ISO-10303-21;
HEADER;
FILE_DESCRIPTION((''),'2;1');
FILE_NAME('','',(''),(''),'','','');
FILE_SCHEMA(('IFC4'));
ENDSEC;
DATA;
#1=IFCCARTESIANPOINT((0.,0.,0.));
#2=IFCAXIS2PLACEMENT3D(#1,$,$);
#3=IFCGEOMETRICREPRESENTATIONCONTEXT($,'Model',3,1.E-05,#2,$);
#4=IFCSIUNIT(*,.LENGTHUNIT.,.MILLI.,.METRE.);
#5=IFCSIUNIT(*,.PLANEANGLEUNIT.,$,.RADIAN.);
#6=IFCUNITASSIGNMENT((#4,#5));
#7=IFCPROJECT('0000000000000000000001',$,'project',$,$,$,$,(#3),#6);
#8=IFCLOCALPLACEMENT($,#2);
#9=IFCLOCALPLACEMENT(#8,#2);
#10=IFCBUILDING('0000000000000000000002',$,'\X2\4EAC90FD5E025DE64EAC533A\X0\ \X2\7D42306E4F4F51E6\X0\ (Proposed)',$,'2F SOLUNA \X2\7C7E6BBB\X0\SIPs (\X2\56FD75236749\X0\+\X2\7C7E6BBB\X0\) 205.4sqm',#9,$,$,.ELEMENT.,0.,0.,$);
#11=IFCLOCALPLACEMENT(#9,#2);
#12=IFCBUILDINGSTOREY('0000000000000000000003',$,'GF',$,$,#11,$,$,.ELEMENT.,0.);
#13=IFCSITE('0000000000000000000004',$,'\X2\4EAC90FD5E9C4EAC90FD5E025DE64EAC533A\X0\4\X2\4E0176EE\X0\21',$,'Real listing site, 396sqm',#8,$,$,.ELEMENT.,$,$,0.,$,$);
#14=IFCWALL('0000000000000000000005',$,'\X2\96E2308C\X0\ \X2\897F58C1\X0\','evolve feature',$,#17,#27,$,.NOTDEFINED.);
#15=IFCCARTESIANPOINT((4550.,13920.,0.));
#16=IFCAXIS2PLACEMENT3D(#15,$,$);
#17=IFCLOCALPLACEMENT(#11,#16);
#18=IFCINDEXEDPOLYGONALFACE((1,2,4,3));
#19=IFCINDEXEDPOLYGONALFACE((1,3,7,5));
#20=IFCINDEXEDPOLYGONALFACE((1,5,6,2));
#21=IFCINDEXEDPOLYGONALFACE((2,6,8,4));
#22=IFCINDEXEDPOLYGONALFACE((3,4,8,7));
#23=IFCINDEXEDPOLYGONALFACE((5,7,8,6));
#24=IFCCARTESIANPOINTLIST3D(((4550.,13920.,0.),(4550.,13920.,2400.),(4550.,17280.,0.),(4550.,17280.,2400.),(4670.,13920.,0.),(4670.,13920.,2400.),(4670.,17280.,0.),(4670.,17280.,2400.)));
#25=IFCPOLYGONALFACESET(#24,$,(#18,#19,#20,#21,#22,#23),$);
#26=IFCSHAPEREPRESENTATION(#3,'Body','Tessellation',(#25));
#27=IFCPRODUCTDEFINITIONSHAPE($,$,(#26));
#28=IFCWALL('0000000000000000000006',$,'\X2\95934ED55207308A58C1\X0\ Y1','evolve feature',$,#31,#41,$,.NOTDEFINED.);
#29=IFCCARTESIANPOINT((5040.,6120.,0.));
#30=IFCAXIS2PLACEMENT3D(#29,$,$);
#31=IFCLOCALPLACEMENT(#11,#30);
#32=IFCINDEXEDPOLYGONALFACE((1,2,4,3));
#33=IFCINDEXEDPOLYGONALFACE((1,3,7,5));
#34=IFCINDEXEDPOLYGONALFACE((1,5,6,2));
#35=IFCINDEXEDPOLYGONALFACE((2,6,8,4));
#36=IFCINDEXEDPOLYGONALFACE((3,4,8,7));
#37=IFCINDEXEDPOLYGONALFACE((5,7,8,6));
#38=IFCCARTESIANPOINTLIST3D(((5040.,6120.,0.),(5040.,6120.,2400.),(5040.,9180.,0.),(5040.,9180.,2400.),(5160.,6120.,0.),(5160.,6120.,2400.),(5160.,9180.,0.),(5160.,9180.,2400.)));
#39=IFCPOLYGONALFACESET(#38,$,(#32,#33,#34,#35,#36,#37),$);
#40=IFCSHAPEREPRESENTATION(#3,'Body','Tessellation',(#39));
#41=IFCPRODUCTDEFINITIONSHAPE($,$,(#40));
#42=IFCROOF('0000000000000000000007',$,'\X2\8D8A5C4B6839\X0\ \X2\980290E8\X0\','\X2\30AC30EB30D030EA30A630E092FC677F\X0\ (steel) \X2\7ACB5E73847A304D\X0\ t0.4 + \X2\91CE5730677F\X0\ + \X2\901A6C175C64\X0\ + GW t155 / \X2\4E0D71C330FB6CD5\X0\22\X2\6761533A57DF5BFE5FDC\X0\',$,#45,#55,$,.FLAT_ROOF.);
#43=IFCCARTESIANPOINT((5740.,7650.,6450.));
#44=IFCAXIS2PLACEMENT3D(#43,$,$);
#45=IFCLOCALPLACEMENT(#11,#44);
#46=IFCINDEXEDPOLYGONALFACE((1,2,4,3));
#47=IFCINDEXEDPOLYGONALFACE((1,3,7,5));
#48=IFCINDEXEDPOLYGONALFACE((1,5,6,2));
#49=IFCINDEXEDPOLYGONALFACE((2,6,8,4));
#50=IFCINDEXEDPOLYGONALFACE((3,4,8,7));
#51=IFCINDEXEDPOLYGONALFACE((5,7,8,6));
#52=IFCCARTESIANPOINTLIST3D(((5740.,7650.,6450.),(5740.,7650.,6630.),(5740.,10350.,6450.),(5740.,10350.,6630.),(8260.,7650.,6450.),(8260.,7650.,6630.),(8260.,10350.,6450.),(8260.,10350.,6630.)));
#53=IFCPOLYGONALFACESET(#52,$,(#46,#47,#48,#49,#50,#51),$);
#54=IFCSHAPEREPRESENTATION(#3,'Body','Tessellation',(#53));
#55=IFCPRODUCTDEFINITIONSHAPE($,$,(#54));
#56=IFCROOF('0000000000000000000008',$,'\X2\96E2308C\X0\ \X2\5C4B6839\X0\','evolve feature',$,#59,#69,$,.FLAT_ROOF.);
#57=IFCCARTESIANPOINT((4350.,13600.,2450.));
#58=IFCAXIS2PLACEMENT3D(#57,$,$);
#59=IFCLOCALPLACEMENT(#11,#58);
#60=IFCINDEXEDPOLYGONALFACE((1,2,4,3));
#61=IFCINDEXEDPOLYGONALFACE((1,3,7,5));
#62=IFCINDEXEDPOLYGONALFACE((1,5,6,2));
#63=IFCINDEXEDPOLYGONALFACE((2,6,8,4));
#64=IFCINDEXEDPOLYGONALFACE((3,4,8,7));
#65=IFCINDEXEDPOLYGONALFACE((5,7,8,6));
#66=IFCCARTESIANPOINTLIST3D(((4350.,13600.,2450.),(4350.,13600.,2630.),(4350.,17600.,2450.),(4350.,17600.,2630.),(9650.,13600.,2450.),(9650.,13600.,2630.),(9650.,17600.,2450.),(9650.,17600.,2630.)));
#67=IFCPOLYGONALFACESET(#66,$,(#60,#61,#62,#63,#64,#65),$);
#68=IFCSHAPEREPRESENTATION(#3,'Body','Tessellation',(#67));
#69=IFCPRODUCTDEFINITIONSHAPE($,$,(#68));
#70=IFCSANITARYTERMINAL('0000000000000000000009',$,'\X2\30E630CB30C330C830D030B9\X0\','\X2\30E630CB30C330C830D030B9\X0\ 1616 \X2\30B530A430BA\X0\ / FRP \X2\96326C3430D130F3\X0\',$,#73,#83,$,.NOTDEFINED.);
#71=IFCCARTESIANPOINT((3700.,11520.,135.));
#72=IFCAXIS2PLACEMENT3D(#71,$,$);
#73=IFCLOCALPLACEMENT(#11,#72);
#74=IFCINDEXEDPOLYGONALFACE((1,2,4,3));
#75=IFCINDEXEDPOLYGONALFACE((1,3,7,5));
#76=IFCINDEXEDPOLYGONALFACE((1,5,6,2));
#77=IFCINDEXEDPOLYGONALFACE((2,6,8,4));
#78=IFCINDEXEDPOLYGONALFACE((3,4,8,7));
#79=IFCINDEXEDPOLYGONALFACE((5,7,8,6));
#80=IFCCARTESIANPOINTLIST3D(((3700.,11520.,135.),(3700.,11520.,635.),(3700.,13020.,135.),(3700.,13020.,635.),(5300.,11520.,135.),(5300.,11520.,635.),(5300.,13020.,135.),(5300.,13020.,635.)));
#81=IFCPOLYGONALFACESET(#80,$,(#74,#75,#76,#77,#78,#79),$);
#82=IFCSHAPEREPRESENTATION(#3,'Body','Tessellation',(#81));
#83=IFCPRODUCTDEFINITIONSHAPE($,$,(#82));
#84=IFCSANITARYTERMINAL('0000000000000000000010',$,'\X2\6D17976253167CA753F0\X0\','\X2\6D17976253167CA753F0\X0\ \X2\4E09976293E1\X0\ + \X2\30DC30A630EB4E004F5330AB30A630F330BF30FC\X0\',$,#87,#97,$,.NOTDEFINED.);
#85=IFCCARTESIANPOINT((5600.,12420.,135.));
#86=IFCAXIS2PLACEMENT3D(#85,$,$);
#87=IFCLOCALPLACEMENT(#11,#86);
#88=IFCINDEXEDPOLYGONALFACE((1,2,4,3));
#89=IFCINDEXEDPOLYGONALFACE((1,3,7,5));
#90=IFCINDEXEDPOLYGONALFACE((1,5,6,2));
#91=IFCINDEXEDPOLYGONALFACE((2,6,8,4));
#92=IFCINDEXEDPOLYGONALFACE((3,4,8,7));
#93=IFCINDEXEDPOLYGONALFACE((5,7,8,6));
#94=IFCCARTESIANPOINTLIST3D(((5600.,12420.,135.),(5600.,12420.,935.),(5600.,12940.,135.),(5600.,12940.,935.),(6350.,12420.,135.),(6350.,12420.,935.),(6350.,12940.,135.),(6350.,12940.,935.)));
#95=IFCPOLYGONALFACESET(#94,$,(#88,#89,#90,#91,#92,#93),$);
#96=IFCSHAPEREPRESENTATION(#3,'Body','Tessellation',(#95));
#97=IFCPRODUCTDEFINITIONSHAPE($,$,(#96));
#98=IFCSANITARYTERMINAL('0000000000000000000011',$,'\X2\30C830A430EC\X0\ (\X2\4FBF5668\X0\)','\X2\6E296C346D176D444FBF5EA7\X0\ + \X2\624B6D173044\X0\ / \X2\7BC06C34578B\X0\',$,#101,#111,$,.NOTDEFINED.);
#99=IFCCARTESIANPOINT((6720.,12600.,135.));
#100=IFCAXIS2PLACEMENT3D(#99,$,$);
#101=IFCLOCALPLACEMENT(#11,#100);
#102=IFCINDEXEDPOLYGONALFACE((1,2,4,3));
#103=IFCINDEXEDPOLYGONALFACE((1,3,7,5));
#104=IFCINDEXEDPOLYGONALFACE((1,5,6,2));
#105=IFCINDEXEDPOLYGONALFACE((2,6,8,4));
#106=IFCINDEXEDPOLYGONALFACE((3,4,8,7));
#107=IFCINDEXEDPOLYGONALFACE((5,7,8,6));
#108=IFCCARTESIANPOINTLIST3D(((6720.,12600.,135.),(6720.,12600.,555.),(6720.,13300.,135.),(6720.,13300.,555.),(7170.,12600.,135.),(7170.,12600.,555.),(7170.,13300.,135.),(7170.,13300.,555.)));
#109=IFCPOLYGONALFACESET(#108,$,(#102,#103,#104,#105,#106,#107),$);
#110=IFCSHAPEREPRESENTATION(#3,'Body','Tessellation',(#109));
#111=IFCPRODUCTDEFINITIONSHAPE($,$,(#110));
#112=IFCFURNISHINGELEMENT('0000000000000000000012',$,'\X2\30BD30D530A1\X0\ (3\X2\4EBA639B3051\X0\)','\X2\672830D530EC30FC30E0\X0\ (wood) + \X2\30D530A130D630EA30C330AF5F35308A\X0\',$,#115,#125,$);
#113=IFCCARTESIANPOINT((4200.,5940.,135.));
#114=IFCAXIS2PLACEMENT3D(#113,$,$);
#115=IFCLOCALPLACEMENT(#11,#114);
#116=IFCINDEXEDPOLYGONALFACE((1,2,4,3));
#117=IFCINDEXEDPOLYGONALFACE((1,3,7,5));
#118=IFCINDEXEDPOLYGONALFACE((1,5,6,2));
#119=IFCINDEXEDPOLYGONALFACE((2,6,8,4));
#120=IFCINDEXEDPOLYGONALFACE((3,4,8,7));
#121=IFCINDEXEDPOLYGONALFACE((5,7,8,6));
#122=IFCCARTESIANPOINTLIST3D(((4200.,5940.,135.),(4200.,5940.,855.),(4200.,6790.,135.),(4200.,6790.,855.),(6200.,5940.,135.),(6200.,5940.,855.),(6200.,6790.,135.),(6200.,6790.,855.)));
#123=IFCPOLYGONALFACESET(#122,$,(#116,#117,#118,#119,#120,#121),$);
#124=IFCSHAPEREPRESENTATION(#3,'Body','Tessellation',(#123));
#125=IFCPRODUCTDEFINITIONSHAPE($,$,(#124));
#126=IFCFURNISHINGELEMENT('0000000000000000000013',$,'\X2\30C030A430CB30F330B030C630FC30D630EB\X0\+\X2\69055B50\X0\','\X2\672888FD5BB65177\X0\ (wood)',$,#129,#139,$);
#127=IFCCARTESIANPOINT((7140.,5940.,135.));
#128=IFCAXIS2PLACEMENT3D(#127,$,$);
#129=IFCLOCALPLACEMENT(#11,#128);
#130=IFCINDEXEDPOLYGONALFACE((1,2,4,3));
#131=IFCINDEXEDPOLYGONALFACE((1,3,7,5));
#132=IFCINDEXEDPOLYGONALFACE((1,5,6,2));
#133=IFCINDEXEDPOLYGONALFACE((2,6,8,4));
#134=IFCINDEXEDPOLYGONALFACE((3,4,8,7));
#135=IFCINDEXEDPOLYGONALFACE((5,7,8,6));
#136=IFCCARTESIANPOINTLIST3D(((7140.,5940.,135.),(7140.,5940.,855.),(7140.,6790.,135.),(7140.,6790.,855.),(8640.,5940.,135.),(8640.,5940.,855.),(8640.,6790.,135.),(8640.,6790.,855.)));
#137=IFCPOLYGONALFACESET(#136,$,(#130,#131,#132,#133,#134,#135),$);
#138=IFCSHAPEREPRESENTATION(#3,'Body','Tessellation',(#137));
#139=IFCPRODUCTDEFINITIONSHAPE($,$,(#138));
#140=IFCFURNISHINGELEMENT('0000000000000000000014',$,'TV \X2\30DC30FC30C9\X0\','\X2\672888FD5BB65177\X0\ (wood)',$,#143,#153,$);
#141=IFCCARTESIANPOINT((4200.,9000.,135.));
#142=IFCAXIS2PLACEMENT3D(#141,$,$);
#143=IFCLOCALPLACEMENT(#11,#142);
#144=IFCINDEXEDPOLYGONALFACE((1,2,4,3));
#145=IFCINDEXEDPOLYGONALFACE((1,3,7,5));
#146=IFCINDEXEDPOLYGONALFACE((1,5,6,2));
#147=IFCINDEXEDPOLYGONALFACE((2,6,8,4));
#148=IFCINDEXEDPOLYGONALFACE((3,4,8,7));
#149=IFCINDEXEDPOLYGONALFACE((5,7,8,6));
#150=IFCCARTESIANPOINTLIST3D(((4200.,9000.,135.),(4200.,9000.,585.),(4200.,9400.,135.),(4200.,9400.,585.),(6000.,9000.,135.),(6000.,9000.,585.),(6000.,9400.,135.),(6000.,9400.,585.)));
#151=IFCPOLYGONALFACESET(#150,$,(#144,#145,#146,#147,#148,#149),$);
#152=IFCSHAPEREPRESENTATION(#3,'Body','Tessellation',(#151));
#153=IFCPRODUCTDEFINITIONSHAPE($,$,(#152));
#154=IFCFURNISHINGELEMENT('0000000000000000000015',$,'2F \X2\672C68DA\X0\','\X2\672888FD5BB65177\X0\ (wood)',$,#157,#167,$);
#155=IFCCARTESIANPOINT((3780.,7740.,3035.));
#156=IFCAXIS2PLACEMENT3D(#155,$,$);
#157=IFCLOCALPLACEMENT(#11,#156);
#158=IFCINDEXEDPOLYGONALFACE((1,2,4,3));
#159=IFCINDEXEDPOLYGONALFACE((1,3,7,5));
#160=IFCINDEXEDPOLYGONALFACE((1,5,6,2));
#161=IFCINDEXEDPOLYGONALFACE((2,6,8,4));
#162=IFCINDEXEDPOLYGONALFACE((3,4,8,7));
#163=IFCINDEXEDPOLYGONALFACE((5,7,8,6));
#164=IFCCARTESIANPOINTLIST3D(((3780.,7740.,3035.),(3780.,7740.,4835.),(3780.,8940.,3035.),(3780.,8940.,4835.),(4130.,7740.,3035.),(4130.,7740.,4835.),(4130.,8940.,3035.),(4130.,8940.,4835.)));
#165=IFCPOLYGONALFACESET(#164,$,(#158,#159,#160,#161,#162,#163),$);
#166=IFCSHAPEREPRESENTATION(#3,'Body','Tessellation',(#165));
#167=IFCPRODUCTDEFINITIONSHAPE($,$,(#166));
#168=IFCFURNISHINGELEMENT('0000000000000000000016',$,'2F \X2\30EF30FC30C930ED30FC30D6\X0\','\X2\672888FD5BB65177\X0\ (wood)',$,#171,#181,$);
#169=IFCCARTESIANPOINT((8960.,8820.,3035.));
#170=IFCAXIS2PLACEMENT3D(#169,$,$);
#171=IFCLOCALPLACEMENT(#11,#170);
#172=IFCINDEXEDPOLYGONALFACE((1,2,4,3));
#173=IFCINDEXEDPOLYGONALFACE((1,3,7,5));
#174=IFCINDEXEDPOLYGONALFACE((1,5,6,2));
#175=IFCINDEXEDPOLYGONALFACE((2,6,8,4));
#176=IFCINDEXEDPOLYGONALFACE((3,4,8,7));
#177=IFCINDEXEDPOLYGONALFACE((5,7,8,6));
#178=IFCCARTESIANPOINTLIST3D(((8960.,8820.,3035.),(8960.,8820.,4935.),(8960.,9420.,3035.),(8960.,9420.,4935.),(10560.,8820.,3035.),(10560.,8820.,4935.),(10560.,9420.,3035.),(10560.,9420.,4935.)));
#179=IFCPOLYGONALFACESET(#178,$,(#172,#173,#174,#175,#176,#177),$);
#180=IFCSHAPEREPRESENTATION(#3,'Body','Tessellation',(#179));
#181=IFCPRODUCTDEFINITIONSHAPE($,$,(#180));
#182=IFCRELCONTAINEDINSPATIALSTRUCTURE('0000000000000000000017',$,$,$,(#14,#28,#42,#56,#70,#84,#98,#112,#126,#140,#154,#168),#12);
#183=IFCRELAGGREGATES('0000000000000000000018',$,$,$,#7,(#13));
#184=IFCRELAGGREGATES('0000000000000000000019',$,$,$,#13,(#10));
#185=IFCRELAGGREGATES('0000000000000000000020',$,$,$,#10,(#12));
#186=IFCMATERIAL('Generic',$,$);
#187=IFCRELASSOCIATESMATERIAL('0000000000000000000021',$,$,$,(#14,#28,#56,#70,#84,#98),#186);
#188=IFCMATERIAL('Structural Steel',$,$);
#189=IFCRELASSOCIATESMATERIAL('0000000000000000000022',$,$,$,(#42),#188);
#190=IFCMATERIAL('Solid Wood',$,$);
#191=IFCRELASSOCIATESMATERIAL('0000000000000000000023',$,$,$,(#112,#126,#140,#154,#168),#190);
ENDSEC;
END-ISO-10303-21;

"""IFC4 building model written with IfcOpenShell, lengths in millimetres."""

from ifc_helpers import new_model, si_unit, frame, frame_2d, origin, place, context, project, spatial, rectangle, extrude, material, element, save


model = new_model("IFC4")

# Units and contexts
model_context = context("Model", 3, precision=1e-05, world=origin())
ifc_project = project(units=[si_unit("LENGTHUNIT", "METRE", prefix="MILLI"), si_unit("PLANEANGLEUNIT", "RADIAN")], contexts=[model_context])

# Site, building, storey
site_placement = place(None, origin())
site = spatial("IfcSite", under=ifc_project, at=site_placement, Name="京都府京都市左京区4丁目21", ObjectType="Real listing site, 396sqm", CompositionType="ELEMENT", RefElevation=0.0)
building_placement = place(site_placement, origin())
building = spatial("IfcBuilding", under=site, at=building_placement, Name="京都市左京区 終の住処 (Proposed)", ObjectType="2F SOLUNA 籾殻SIPs (国産杉+籾殻) 205.4sqm", CompositionType="ELEMENT", ElevationOfRefHeight=0.0, ElevationOfTerrain=0.0)
storey_placement = place(building_placement, origin())
storey = spatial("IfcBuildingStorey", under=building, at=storey_placement, Name="GF", CompositionType="ELEMENT", Elevation=0.0)

# Shared definitions
ifc_material_1 = material(Name="Generic")

# Shared definitions
ifc_material_2 = material(Name="Solid Wood")

# Walls
wall_1_placement = place(storey_placement, frame((4550.0, 13920.0, 0.0)))
element("IfcWall", 1, at=wall_1_placement, inside=storey, material=ifc_material_1, Name="離れ 西壁", Description="evolve feature", PredefinedType="NOTDEFINED", context=model_context, shape_type="SweptSolid", body=[
    extrude(rectangle(XDim=120.0, YDim=3360.0, at=frame_2d((60.0, 1680.0))), frame((4550.0, 13920.0, 0.0)), (0.0, 0.0, 1.0), 2400.0),
])
wall_2_placement = place(storey_placement, frame((5040.0, 6120.0, 0.0)))
element("IfcWall", 2, at=wall_2_placement, inside=storey, material=ifc_material_1, Name="間仕切り壁 Y1", Description="evolve feature", PredefinedType="NOTDEFINED", context=model_context, shape_type="SweptSolid", body=[
    extrude(rectangle(XDim=120.0, YDim=3060.0, at=frame_2d((60.0, 1530.0))), frame((5040.0, 6120.0, 0.0)), (0.0, 0.0, 1.0), 2400.0),
])

# Roofs
ifc_material_3 = material(Name="Structural Steel")
roof_1_placement = place(storey_placement, frame((5740.0, 7650.0, 6450.0)))
element("IfcRoof", 3, at=roof_1_placement, inside=storey, material=ifc_material_3, Name="越屋根 頂部", Description="ガルバリウム鋼板 (steel) 立平葺き t0.4 + 野地板 + 通気層 + GW t155 / 不燃・法22条区域対応", PredefinedType="FLAT_ROOF", context=model_context, shape_type="SweptSolid", body=[
    extrude(rectangle(XDim=2520.0, YDim=2700.0, at=frame_2d((1260.0, 1350.0))), frame((5740.0, 7650.0, 6450.0)), (0.0, 0.0, 1.0), 180.0),
])
roof_2_placement = place(storey_placement, frame((4350.0, 13600.0, 2450.0)))
element("IfcRoof", 4, at=roof_2_placement, inside=storey, material=ifc_material_1, Name="離れ 屋根", Description="evolve feature", PredefinedType="FLAT_ROOF", context=model_context, shape_type="SweptSolid", body=[
    extrude(rectangle(XDim=5300.0, YDim=4000.0, at=frame_2d((2650.0, 2000.0))), frame((4350.0, 13600.0, 2450.0)), (0.0, 0.0, 1.0), 180.0),
])

# Sanitary terminals
sanitary_terminal_1_placement = place(storey_placement, frame((3700.0, 11520.0, 135.0)))
element("IfcSanitaryTerminal", 5, at=sanitary_terminal_1_placement, inside=storey, material=ifc_material_1, Name="ユニットバス", Description="ユニットバス 1616 サイズ / FRP 防水パン", PredefinedType="NOTDEFINED", context=model_context, shape_type="SweptSolid", body=[
    extrude(rectangle(XDim=1600.0, YDim=1500.0, at=frame_2d((800.0, 750.0))), frame((3700.0, 11520.0, 135.0)), (0.0, 0.0, 1.0), 500.0),
])
sanitary_terminal_2_placement = place(storey_placement, frame((5600.0, 12420.0, 135.0)))
element("IfcSanitaryTerminal", 6, at=sanitary_terminal_2_placement, inside=storey, material=ifc_material_1, Name="洗面化粧台", Description="洗面化粧台 三面鏡 + ボウル一体カウンター", PredefinedType="NOTDEFINED", context=model_context, shape_type="SweptSolid", body=[
    extrude(rectangle(XDim=750.0, YDim=520.0, at=frame_2d((375.0, 260.0))), frame((5600.0, 12420.0, 135.0)), (0.0, 0.0, 1.0), 800.0),
])
sanitary_terminal_3_placement = place(storey_placement, frame((6720.0, 12600.0, 135.0)))
element("IfcSanitaryTerminal", 7, at=sanitary_terminal_3_placement, inside=storey, material=ifc_material_1, Name="トイレ (便器)", Description="温水洗浄便座 + 手洗い / 節水型", PredefinedType="NOTDEFINED", context=model_context, shape_type="SweptSolid", body=[
    extrude(rectangle(XDim=450.0, YDim=700.0, at=frame_2d((225.0, 350.0))), frame((6720.0, 12600.0, 135.0)), (0.0, 0.0, 1.0), 420.0),
])

# Furnishing elements
furnishing_1_placement = place(storey_placement, frame((4200.0, 5940.0, 135.0)))
element("IfcFurnishingElement", 8, at=furnishing_1_placement, inside=storey, material=ifc_material_2, Name="ソファ (3人掛け)", Description="木フレーム (wood) + ファブリック張り", context=model_context, shape_type="SweptSolid", body=[
    extrude(rectangle(XDim=2000.0, YDim=850.0, at=frame_2d((1000.0, 425.0))), frame((4200.0, 5940.0, 135.0)), (0.0, 0.0, 1.0), 720.0),
])
furnishing_2_placement = place(storey_placement, frame((7140.0, 5940.0, 135.0)))
element("IfcFurnishingElement", 9, at=furnishing_2_placement, inside=storey, material=ifc_material_2, Name="ダイニングテーブル+椅子", Description="木製家具 (wood)", context=model_context, shape_type="SweptSolid", body=[
    extrude(rectangle(XDim=1500.0, YDim=850.0, at=frame_2d((750.0, 425.0))), frame((7140.0, 5940.0, 135.0)), (0.0, 0.0, 1.0), 720.0),
])
furnishing_3_placement = place(storey_placement, frame((4200.0, 9000.0, 135.0)))
element("IfcFurnishingElement", 10, at=furnishing_3_placement, inside=storey, material=ifc_material_2, Name="TV ボード", Description="木製家具 (wood)", context=model_context, shape_type="SweptSolid", body=[
    extrude(rectangle(XDim=1800.0, YDim=400.0, at=frame_2d((900.0, 200.0))), frame((4200.0, 9000.0, 135.0)), (0.0, 0.0, 1.0), 450.0),
])
furnishing_4_placement = place(storey_placement, frame((3780.0, 7740.0, 3035.0)))
element("IfcFurnishingElement", 11, at=furnishing_4_placement, inside=storey, material=ifc_material_2, Name="2F 本棚", Description="木製家具 (wood)", context=model_context, shape_type="SweptSolid", body=[
    extrude(rectangle(XDim=350.0, YDim=1200.0, at=frame_2d((175.0, 600.0))), frame((3780.0, 7740.0, 3035.0)), (0.0, 0.0, 1.0), 1800.0),
])
furnishing_5_placement = place(storey_placement, frame((8960.0, 8820.0, 3035.0)))
element("IfcFurnishingElement", 12, at=furnishing_5_placement, inside=storey, material=ifc_material_2, Name="2F ワードローブ", Description="木製家具 (wood)", context=model_context, shape_type="SweptSolid", body=[
    extrude(rectangle(XDim=1600.0, YDim=600.0, at=frame_2d((800.0, 300.0))), frame((8960.0, 8820.0, 3035.0)), (0.0, 0.0, 1.0), 1900.0),
])

save(model, "model.ifc")
